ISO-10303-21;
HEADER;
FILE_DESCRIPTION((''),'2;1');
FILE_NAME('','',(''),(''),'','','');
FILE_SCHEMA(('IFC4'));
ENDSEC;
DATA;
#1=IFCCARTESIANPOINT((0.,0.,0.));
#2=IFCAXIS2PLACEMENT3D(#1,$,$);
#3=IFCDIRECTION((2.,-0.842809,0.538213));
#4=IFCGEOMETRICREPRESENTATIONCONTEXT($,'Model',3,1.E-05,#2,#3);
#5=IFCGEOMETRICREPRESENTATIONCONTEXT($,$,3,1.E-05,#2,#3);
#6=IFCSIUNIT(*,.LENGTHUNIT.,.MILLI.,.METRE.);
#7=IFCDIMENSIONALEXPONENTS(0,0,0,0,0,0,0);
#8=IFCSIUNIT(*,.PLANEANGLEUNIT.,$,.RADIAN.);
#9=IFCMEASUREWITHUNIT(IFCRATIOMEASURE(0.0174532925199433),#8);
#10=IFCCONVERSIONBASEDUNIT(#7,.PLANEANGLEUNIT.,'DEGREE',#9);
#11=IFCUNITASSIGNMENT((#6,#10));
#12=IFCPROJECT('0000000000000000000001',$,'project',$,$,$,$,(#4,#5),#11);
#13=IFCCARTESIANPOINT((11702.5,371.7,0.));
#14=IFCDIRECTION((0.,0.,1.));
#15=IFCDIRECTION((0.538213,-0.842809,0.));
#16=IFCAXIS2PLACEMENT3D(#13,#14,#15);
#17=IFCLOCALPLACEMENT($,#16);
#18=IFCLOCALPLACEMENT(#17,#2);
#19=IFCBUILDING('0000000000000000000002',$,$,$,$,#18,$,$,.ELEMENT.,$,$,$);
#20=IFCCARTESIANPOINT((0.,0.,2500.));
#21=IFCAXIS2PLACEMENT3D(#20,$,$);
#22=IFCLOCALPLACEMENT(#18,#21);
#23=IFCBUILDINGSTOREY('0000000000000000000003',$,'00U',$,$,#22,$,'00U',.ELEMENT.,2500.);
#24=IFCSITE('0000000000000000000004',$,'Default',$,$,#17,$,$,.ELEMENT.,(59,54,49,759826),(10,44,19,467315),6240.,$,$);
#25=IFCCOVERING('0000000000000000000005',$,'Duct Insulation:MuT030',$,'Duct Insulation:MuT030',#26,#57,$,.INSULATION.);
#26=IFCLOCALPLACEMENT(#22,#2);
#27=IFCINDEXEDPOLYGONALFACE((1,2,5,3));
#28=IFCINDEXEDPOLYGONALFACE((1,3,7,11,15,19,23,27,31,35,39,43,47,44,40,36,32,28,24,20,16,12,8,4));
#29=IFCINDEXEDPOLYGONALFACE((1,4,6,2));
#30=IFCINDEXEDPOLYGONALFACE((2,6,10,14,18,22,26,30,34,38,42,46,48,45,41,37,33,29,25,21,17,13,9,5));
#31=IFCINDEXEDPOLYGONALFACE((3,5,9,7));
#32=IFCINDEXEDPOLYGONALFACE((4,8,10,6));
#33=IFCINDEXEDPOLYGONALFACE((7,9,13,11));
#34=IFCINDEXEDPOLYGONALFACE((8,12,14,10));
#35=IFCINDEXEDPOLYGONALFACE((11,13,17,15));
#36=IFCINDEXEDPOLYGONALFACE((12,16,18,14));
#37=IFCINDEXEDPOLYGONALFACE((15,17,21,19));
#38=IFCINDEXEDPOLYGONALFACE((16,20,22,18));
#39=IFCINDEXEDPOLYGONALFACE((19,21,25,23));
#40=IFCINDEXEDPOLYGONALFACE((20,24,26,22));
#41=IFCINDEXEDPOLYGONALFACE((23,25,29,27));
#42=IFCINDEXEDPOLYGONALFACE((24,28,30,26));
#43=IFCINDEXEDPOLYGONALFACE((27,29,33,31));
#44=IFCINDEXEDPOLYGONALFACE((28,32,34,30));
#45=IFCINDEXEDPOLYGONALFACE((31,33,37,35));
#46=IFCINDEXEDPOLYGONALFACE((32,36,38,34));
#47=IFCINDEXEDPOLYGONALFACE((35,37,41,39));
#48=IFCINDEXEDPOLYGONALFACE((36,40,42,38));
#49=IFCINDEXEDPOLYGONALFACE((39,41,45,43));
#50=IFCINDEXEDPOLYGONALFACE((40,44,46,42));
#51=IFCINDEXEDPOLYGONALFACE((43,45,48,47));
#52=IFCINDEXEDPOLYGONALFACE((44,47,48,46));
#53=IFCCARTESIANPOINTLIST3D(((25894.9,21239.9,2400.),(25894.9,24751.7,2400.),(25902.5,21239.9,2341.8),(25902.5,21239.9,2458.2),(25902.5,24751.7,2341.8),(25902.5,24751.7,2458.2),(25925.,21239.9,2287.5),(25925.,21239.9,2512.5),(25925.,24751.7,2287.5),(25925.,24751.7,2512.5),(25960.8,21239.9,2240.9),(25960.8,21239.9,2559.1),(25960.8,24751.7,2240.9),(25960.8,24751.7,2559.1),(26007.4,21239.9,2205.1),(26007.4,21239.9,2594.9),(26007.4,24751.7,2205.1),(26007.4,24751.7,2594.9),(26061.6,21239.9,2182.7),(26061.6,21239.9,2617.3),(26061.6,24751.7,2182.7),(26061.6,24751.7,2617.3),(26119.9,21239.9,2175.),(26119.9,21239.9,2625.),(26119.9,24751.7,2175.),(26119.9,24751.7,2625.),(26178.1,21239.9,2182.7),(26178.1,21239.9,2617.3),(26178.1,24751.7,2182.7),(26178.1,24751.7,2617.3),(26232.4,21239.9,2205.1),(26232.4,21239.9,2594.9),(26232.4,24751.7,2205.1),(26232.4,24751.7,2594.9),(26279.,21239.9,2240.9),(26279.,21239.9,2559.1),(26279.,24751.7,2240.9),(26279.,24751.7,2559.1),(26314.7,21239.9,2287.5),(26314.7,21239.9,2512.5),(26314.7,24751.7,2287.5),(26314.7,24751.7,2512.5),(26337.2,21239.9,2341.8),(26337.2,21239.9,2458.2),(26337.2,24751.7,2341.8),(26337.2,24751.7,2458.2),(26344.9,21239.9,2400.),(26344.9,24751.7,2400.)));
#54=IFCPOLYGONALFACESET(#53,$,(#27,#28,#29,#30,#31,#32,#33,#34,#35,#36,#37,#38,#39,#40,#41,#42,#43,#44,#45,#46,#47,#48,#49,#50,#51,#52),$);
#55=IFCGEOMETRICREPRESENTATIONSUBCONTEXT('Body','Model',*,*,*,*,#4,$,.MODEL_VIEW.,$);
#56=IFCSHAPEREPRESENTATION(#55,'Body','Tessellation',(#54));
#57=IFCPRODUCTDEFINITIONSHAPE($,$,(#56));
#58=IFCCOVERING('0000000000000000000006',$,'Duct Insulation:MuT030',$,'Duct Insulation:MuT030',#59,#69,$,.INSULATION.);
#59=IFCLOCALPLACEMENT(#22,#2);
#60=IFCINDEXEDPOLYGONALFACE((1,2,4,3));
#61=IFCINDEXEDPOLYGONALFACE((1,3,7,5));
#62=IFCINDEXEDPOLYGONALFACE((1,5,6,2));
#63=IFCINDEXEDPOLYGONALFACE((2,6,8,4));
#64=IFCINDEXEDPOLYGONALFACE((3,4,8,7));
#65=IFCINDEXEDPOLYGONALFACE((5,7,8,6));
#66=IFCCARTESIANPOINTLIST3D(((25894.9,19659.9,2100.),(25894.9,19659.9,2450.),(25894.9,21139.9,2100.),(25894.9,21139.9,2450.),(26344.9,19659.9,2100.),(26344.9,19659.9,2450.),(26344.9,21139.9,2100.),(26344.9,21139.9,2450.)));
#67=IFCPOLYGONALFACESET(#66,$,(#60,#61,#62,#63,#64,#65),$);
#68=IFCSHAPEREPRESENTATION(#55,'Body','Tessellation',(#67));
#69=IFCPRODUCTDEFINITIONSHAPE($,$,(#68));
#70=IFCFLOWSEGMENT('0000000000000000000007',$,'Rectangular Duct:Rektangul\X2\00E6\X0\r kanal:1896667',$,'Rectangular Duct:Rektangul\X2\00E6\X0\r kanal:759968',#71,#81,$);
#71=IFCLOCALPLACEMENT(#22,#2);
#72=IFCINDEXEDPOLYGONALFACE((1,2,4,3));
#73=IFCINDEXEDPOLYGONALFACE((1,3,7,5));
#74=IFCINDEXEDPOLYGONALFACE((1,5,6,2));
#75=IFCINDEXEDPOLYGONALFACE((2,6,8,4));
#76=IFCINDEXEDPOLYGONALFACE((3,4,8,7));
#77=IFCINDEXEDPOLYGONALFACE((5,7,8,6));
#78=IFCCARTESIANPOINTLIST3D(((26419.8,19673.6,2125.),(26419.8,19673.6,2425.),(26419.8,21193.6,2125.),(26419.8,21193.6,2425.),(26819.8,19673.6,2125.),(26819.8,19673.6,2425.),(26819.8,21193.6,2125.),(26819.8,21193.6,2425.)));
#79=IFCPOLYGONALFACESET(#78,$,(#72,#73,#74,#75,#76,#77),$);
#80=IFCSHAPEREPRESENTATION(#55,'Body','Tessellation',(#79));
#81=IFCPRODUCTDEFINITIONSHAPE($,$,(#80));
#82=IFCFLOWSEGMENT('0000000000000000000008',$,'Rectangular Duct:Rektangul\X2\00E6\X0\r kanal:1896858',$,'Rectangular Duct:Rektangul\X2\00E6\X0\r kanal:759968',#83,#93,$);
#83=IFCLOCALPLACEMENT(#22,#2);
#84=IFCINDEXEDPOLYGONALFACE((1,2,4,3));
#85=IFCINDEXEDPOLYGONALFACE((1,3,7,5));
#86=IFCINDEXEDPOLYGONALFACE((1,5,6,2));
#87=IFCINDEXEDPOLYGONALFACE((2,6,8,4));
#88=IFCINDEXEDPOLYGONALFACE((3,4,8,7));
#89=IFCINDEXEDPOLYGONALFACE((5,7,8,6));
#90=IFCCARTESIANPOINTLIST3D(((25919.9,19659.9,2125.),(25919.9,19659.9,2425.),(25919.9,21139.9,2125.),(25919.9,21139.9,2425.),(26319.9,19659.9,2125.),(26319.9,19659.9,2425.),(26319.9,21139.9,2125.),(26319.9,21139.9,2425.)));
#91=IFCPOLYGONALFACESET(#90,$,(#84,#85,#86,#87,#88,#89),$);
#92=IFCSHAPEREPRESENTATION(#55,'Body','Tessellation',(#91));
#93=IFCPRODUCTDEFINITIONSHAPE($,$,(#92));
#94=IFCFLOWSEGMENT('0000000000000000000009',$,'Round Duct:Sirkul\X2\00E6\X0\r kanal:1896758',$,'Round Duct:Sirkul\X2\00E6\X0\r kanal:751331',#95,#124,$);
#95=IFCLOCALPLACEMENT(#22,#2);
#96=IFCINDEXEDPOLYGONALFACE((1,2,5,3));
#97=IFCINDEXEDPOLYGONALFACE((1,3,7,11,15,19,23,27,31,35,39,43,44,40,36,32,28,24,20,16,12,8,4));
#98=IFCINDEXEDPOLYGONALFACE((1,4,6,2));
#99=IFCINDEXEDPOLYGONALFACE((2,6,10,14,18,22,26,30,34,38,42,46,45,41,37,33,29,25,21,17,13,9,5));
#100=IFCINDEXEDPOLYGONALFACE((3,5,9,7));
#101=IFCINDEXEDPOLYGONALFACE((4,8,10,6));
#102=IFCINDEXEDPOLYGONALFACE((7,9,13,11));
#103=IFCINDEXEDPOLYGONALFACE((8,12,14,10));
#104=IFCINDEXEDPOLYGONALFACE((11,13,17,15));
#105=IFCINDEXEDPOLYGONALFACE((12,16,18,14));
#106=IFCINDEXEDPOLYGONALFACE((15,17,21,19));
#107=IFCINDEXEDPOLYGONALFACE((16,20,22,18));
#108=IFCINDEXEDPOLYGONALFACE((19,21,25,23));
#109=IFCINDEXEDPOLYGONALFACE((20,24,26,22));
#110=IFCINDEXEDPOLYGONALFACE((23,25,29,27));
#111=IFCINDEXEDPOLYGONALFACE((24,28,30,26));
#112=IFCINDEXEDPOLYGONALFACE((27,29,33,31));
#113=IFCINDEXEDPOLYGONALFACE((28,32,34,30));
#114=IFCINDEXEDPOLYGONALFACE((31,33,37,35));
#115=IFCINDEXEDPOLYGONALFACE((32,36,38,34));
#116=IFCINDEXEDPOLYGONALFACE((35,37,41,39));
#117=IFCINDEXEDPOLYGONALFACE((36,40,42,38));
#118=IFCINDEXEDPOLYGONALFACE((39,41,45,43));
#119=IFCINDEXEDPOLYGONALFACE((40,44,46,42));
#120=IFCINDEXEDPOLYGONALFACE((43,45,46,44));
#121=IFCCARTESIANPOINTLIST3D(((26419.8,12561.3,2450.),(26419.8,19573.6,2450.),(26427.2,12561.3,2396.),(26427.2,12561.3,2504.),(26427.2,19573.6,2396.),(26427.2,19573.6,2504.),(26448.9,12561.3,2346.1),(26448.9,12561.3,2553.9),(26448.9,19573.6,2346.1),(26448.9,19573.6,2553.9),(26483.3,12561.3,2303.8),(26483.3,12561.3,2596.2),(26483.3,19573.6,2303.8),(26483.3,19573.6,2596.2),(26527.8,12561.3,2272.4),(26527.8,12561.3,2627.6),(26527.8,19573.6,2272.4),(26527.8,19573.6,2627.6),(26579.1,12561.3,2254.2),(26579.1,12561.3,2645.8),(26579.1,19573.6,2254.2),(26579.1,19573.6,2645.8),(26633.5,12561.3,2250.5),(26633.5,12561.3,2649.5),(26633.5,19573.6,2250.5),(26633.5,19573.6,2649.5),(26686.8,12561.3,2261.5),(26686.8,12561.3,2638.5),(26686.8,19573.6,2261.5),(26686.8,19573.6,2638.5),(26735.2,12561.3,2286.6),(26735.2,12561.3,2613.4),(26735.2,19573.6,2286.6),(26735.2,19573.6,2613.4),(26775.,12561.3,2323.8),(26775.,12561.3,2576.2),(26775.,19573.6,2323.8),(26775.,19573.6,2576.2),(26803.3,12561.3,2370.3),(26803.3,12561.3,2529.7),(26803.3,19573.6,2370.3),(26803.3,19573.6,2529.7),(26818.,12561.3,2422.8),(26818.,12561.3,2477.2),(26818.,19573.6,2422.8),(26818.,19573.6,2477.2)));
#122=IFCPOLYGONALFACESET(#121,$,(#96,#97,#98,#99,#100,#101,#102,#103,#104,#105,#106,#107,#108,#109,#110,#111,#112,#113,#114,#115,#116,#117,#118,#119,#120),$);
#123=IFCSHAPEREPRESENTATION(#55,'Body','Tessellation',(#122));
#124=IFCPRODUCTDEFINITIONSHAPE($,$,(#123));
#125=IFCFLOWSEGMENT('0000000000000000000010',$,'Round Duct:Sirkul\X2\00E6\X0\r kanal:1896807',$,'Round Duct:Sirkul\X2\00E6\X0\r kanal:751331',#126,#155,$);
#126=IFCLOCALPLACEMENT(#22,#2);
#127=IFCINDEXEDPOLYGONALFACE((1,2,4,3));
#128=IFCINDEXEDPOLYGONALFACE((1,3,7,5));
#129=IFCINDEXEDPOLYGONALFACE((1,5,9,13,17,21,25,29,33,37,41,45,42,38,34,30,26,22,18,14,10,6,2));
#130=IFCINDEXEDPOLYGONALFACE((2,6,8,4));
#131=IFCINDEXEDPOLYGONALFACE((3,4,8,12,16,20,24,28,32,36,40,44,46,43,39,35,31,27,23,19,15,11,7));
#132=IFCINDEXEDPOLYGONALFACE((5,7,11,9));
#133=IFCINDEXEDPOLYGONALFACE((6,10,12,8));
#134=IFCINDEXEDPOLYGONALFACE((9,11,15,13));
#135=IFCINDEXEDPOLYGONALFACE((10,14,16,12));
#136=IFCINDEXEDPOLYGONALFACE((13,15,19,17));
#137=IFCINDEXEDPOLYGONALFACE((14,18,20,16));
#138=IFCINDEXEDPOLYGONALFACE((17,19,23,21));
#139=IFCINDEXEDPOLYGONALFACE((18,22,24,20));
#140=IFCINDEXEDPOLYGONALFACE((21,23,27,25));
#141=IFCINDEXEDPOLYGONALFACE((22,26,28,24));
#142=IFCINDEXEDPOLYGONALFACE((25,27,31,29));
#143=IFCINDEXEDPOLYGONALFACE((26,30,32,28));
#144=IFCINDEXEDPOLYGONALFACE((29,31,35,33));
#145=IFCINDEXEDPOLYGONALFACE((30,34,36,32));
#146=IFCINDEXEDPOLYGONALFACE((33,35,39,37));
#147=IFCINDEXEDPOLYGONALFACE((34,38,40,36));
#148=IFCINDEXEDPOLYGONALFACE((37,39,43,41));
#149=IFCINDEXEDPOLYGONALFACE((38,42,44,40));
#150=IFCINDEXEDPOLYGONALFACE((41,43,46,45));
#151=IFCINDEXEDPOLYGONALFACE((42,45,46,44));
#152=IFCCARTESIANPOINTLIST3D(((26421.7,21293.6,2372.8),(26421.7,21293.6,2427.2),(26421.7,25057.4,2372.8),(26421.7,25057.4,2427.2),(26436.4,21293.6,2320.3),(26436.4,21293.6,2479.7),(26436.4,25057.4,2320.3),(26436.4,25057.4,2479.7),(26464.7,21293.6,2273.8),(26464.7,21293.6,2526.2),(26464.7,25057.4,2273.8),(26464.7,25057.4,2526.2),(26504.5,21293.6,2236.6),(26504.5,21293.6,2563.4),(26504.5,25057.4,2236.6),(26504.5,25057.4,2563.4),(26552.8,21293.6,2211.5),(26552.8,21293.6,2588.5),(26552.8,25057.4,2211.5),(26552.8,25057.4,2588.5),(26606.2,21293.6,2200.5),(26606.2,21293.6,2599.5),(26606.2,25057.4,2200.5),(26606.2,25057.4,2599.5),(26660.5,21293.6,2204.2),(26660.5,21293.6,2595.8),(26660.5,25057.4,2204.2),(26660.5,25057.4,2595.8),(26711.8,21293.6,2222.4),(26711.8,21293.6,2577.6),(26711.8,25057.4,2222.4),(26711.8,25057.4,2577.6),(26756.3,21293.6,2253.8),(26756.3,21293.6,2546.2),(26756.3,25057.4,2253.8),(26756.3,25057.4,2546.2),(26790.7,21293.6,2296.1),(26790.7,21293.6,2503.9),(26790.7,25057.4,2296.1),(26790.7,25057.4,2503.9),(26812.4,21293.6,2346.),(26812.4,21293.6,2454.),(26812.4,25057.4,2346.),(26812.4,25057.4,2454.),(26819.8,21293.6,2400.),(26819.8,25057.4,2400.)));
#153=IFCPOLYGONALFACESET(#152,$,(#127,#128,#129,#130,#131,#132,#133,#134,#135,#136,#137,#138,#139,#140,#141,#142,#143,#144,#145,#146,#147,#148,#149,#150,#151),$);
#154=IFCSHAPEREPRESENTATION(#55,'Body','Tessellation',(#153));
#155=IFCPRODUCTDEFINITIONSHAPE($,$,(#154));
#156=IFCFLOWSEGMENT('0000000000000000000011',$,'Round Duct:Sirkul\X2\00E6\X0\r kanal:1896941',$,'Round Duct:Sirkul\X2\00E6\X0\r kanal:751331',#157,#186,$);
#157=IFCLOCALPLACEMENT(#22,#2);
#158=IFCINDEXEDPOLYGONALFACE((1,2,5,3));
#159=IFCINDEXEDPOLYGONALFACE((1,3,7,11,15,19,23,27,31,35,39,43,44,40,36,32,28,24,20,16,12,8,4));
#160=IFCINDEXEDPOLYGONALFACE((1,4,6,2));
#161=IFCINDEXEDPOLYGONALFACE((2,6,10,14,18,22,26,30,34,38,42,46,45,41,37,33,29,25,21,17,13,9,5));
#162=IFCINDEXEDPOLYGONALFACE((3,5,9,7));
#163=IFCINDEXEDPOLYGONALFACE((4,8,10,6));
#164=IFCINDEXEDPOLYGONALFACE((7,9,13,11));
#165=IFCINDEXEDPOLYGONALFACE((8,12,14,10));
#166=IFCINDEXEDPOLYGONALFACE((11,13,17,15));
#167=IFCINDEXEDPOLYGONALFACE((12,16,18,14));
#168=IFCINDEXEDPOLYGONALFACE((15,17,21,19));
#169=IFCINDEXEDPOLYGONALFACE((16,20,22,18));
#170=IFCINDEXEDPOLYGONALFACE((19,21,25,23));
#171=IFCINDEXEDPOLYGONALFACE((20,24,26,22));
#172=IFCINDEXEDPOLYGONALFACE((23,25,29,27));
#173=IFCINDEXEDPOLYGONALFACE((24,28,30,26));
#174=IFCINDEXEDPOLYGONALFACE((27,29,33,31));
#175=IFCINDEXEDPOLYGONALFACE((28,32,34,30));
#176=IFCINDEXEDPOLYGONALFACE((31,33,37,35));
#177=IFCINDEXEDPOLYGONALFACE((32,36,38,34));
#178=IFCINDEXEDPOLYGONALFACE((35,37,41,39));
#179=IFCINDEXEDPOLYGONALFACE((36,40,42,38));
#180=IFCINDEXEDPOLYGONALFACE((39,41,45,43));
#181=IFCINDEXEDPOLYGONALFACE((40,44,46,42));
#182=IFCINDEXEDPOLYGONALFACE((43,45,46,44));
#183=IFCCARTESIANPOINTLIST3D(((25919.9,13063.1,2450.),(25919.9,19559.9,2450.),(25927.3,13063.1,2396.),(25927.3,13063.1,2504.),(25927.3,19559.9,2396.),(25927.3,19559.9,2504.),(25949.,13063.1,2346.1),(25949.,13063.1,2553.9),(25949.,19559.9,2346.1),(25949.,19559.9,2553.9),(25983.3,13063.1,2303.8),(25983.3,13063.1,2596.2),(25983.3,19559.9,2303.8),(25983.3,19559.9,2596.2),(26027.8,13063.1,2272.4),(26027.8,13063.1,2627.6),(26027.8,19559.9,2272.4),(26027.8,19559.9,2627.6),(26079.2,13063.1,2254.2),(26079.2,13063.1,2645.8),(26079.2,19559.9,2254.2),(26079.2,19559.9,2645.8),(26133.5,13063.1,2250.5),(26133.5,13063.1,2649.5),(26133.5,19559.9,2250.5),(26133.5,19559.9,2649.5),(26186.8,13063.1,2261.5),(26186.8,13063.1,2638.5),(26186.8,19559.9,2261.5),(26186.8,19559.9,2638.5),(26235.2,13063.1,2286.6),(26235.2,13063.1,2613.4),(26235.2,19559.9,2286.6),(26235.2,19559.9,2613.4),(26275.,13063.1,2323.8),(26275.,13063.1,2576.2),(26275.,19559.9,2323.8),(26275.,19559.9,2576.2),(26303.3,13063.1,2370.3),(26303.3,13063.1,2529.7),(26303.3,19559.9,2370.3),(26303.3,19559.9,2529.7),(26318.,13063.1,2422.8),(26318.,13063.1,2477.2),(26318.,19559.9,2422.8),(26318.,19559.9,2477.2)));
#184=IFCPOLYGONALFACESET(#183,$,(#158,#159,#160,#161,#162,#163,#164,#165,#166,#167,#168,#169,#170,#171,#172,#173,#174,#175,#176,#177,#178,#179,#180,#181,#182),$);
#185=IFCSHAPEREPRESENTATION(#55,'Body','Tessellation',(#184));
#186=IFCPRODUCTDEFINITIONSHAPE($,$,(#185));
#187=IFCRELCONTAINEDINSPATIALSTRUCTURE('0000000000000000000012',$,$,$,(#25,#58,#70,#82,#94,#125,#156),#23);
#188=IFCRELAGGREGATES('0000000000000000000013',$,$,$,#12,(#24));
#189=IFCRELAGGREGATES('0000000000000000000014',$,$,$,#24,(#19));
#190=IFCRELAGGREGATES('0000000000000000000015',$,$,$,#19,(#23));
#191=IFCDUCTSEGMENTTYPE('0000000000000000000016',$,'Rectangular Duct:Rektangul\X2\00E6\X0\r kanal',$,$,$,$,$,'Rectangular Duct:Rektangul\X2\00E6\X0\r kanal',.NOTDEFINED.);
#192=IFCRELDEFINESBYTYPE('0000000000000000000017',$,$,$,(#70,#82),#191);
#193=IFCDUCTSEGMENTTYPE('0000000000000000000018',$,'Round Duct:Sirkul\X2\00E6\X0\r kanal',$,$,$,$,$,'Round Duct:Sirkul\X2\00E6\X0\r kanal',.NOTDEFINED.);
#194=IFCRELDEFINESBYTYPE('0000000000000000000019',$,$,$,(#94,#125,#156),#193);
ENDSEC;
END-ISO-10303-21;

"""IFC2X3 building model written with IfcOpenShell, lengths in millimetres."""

from ifc_helpers import new_model, entity, si_unit, converted_unit, direction, frame, frame_2d, origin, origin_2d_with_axis, place, context, subcontext, project, spatial, rectangle, circle, extrude, type_object, element, save


model = new_model("IFC2X3")

# Units and contexts
model_context = context("Model", 3, precision=1e-05, world=origin(), true_north=direction((2.0, -0.842809, 0.538213)))
context_of_model = context(None, 3, precision=1e-05, world=origin(), true_north=direction((2.0, -0.842809, 0.538213)))
body_context = subcontext(model_context, "Body", "Model", "MODEL_VIEW")
ifc_project = project(units=[si_unit("LENGTHUNIT", "METRE", prefix="MILLI"), converted_unit("PLANEANGLEUNIT", "DEGREE", entity("IfcRatioMeasure", 0.0174532925199433), si_unit("PLANEANGLEUNIT", "RADIAN"), dimensions=[0, 0, 0, 0, 0, 0, 0])], contexts=[model_context, context_of_model])

# Site, building, storey
site_placement = place(None, frame((11702.5, 371.7, 0.0), z_axis=(0.0, 0.0, 1.0), x_axis=(0.538213, -0.842809, 0.0)))
site = spatial("IfcSite", under=ifc_project, at=site_placement, Name="Default", CompositionType="ELEMENT", RefLatitude=(59, 54, 49, 759826), RefLongitude=(10, 44, 19, 467315), RefElevation=6240.0)
building_placement = place(site_placement, origin())
building = spatial("IfcBuilding", under=site, at=building_placement, CompositionType="ELEMENT")
storey_placement = place(building_placement, frame((0.0, 0.0, 2500.0)))
storey = spatial("IfcBuildingStorey", under=building, at=storey_placement, Name="00U", LongName="00U", CompositionType="ELEMENT", Elevation=2500.0)

# Coverings
covering_1_placement = place(storey_placement, origin())
element("IfcCovering", 1, at=covering_1_placement, inside=storey, Name="Duct Insulation:MuT030", ObjectType="Duct Insulation:MuT030", PredefinedType="INSULATION", context=body_context, shape_type="SweptSolid", body=[
    extrude(circle(Radius=225.0, at=origin_2d_with_axis()), frame((26119.9, 21239.9, 2400.0), z_axis=(0.0, 1.0, 0.0), x_axis=(-1.0, 0.0, 0.0)), (0.0, 0.0, 1.0), 3511.7),
])
covering_2_placement = place(storey_placement, origin())
element("IfcCovering", 2, at=covering_2_placement, inside=storey, Name="Duct Insulation:MuT030", ObjectType="Duct Insulation:MuT030", PredefinedType="INSULATION", context=body_context, shape_type="SweptSolid", body=[
    extrude(rectangle(XDim=1480.0, YDim=450.0, at=frame_2d((0.0, 0.0), x_axis=(1.0, 0.0))), frame((26119.9, 20399.9, 2100.0), z_axis=(0.0, 0.0, 1.0), x_axis=(0.0, 1.0, 0.0)), (0.0, 0.0, 1.0), 350.0),
])

# Flow segments
duct_segment_type_1 = type_object("IfcDuctSegmentType", Name="Rectangular Duct:Rektangulær kanal", ElementType="Rectangular Duct:Rektangulær kanal", PredefinedType="NOTDEFINED")
flow_segment_1_placement = place(storey_placement, origin())
element("IfcFlowSegment", 3, at=flow_segment_1_placement, inside=storey, type_object=duct_segment_type_1, Name="Rectangular Duct:Rektangulær kanal:1896667", ObjectType="Rectangular Duct:Rektangulær kanal:759968", context=body_context, shape_type="SweptSolid", body=[
    extrude(rectangle(XDim=1520.0, YDim=400.0, at=origin_2d_with_axis()), frame((26619.8, 20433.6, 2125.0), z_axis=(0.0, 0.0, 1.0), x_axis=(0.0, 1.0, 0.0)), (0.0, 0.0, 1.0), 300.0),
])
flow_segment_2_placement = place(storey_placement, origin())
element("IfcFlowSegment", 4, at=flow_segment_2_placement, inside=storey, type_object=duct_segment_type_1, Name="Rectangular Duct:Rektangulær kanal:1896858", ObjectType="Rectangular Duct:Rektangulær kanal:759968", context=body_context, shape_type="SweptSolid", body=[
    extrude(rectangle(XDim=1480.0, YDim=400.0, at=origin_2d_with_axis()), frame((26119.9, 20399.9, 2125.0), z_axis=(0.0, 0.0, 1.0), x_axis=(0.0, 1.0, 0.0)), (0.0, 0.0, 1.0), 300.0),
])
duct_segment_type_2 = type_object("IfcDuctSegmentType", Name="Round Duct:Sirkulær kanal", ElementType="Round Duct:Sirkulær kanal", PredefinedType="NOTDEFINED")
flow_segment_3_placement = place(storey_placement, origin())
element("IfcFlowSegment", 5, at=flow_segment_3_placement, inside=storey, type_object=duct_segment_type_2, Name="Round Duct:Sirkulær kanal:1896758", ObjectType="Round Duct:Sirkulær kanal:751331", context=body_context, shape_type="SweptSolid", body=[
    extrude(circle(Radius=200.0, at=frame_2d((0.0, 0.0), x_axis=(1.0, 0.0))), frame((26619.8, 12561.3, 2450.0), z_axis=(0.0, 1.0, 0.0), x_axis=(-1.0, 0.0, 0.0)), (0.0, 0.0, 1.0), 7012.3),
])
flow_segment_4_placement = place(storey_placement, origin())
element("IfcFlowSegment", 6, at=flow_segment_4_placement, inside=storey, type_object=duct_segment_type_2, Name="Round Duct:Sirkulær kanal:1896807", ObjectType="Round Duct:Sirkulær kanal:751331", context=body_context, shape_type="SweptSolid", body=[
    extrude(circle(Radius=200.0, at=frame_2d((0.0, 0.0), x_axis=(1.0, 0.0))), frame((26619.8, 21293.6, 2400.0), z_axis=(0.0, 1.0, 0.0), x_axis=(1.0, 0.0, 0.0)), (0.0, 0.0, 1.0), 3763.8),
])
flow_segment_5_placement = place(storey_placement, origin())
element("IfcFlowSegment", 7, at=flow_segment_5_placement, inside=storey, type_object=duct_segment_type_2, Name="Round Duct:Sirkulær kanal:1896941", ObjectType="Round Duct:Sirkulær kanal:751331", context=body_context, shape_type="SweptSolid", body=[
    extrude(circle(Radius=200.0, at=frame_2d((0.0, 0.0), x_axis=(1.0, 0.0))), frame((26119.9, 13063.1, 2450.0), z_axis=(0.0, 1.0, 0.0), x_axis=(-1.0, 0.0, 0.0)), (0.0, 0.0, 1.0), 6496.9),
])

save(model, "model.ifc")
